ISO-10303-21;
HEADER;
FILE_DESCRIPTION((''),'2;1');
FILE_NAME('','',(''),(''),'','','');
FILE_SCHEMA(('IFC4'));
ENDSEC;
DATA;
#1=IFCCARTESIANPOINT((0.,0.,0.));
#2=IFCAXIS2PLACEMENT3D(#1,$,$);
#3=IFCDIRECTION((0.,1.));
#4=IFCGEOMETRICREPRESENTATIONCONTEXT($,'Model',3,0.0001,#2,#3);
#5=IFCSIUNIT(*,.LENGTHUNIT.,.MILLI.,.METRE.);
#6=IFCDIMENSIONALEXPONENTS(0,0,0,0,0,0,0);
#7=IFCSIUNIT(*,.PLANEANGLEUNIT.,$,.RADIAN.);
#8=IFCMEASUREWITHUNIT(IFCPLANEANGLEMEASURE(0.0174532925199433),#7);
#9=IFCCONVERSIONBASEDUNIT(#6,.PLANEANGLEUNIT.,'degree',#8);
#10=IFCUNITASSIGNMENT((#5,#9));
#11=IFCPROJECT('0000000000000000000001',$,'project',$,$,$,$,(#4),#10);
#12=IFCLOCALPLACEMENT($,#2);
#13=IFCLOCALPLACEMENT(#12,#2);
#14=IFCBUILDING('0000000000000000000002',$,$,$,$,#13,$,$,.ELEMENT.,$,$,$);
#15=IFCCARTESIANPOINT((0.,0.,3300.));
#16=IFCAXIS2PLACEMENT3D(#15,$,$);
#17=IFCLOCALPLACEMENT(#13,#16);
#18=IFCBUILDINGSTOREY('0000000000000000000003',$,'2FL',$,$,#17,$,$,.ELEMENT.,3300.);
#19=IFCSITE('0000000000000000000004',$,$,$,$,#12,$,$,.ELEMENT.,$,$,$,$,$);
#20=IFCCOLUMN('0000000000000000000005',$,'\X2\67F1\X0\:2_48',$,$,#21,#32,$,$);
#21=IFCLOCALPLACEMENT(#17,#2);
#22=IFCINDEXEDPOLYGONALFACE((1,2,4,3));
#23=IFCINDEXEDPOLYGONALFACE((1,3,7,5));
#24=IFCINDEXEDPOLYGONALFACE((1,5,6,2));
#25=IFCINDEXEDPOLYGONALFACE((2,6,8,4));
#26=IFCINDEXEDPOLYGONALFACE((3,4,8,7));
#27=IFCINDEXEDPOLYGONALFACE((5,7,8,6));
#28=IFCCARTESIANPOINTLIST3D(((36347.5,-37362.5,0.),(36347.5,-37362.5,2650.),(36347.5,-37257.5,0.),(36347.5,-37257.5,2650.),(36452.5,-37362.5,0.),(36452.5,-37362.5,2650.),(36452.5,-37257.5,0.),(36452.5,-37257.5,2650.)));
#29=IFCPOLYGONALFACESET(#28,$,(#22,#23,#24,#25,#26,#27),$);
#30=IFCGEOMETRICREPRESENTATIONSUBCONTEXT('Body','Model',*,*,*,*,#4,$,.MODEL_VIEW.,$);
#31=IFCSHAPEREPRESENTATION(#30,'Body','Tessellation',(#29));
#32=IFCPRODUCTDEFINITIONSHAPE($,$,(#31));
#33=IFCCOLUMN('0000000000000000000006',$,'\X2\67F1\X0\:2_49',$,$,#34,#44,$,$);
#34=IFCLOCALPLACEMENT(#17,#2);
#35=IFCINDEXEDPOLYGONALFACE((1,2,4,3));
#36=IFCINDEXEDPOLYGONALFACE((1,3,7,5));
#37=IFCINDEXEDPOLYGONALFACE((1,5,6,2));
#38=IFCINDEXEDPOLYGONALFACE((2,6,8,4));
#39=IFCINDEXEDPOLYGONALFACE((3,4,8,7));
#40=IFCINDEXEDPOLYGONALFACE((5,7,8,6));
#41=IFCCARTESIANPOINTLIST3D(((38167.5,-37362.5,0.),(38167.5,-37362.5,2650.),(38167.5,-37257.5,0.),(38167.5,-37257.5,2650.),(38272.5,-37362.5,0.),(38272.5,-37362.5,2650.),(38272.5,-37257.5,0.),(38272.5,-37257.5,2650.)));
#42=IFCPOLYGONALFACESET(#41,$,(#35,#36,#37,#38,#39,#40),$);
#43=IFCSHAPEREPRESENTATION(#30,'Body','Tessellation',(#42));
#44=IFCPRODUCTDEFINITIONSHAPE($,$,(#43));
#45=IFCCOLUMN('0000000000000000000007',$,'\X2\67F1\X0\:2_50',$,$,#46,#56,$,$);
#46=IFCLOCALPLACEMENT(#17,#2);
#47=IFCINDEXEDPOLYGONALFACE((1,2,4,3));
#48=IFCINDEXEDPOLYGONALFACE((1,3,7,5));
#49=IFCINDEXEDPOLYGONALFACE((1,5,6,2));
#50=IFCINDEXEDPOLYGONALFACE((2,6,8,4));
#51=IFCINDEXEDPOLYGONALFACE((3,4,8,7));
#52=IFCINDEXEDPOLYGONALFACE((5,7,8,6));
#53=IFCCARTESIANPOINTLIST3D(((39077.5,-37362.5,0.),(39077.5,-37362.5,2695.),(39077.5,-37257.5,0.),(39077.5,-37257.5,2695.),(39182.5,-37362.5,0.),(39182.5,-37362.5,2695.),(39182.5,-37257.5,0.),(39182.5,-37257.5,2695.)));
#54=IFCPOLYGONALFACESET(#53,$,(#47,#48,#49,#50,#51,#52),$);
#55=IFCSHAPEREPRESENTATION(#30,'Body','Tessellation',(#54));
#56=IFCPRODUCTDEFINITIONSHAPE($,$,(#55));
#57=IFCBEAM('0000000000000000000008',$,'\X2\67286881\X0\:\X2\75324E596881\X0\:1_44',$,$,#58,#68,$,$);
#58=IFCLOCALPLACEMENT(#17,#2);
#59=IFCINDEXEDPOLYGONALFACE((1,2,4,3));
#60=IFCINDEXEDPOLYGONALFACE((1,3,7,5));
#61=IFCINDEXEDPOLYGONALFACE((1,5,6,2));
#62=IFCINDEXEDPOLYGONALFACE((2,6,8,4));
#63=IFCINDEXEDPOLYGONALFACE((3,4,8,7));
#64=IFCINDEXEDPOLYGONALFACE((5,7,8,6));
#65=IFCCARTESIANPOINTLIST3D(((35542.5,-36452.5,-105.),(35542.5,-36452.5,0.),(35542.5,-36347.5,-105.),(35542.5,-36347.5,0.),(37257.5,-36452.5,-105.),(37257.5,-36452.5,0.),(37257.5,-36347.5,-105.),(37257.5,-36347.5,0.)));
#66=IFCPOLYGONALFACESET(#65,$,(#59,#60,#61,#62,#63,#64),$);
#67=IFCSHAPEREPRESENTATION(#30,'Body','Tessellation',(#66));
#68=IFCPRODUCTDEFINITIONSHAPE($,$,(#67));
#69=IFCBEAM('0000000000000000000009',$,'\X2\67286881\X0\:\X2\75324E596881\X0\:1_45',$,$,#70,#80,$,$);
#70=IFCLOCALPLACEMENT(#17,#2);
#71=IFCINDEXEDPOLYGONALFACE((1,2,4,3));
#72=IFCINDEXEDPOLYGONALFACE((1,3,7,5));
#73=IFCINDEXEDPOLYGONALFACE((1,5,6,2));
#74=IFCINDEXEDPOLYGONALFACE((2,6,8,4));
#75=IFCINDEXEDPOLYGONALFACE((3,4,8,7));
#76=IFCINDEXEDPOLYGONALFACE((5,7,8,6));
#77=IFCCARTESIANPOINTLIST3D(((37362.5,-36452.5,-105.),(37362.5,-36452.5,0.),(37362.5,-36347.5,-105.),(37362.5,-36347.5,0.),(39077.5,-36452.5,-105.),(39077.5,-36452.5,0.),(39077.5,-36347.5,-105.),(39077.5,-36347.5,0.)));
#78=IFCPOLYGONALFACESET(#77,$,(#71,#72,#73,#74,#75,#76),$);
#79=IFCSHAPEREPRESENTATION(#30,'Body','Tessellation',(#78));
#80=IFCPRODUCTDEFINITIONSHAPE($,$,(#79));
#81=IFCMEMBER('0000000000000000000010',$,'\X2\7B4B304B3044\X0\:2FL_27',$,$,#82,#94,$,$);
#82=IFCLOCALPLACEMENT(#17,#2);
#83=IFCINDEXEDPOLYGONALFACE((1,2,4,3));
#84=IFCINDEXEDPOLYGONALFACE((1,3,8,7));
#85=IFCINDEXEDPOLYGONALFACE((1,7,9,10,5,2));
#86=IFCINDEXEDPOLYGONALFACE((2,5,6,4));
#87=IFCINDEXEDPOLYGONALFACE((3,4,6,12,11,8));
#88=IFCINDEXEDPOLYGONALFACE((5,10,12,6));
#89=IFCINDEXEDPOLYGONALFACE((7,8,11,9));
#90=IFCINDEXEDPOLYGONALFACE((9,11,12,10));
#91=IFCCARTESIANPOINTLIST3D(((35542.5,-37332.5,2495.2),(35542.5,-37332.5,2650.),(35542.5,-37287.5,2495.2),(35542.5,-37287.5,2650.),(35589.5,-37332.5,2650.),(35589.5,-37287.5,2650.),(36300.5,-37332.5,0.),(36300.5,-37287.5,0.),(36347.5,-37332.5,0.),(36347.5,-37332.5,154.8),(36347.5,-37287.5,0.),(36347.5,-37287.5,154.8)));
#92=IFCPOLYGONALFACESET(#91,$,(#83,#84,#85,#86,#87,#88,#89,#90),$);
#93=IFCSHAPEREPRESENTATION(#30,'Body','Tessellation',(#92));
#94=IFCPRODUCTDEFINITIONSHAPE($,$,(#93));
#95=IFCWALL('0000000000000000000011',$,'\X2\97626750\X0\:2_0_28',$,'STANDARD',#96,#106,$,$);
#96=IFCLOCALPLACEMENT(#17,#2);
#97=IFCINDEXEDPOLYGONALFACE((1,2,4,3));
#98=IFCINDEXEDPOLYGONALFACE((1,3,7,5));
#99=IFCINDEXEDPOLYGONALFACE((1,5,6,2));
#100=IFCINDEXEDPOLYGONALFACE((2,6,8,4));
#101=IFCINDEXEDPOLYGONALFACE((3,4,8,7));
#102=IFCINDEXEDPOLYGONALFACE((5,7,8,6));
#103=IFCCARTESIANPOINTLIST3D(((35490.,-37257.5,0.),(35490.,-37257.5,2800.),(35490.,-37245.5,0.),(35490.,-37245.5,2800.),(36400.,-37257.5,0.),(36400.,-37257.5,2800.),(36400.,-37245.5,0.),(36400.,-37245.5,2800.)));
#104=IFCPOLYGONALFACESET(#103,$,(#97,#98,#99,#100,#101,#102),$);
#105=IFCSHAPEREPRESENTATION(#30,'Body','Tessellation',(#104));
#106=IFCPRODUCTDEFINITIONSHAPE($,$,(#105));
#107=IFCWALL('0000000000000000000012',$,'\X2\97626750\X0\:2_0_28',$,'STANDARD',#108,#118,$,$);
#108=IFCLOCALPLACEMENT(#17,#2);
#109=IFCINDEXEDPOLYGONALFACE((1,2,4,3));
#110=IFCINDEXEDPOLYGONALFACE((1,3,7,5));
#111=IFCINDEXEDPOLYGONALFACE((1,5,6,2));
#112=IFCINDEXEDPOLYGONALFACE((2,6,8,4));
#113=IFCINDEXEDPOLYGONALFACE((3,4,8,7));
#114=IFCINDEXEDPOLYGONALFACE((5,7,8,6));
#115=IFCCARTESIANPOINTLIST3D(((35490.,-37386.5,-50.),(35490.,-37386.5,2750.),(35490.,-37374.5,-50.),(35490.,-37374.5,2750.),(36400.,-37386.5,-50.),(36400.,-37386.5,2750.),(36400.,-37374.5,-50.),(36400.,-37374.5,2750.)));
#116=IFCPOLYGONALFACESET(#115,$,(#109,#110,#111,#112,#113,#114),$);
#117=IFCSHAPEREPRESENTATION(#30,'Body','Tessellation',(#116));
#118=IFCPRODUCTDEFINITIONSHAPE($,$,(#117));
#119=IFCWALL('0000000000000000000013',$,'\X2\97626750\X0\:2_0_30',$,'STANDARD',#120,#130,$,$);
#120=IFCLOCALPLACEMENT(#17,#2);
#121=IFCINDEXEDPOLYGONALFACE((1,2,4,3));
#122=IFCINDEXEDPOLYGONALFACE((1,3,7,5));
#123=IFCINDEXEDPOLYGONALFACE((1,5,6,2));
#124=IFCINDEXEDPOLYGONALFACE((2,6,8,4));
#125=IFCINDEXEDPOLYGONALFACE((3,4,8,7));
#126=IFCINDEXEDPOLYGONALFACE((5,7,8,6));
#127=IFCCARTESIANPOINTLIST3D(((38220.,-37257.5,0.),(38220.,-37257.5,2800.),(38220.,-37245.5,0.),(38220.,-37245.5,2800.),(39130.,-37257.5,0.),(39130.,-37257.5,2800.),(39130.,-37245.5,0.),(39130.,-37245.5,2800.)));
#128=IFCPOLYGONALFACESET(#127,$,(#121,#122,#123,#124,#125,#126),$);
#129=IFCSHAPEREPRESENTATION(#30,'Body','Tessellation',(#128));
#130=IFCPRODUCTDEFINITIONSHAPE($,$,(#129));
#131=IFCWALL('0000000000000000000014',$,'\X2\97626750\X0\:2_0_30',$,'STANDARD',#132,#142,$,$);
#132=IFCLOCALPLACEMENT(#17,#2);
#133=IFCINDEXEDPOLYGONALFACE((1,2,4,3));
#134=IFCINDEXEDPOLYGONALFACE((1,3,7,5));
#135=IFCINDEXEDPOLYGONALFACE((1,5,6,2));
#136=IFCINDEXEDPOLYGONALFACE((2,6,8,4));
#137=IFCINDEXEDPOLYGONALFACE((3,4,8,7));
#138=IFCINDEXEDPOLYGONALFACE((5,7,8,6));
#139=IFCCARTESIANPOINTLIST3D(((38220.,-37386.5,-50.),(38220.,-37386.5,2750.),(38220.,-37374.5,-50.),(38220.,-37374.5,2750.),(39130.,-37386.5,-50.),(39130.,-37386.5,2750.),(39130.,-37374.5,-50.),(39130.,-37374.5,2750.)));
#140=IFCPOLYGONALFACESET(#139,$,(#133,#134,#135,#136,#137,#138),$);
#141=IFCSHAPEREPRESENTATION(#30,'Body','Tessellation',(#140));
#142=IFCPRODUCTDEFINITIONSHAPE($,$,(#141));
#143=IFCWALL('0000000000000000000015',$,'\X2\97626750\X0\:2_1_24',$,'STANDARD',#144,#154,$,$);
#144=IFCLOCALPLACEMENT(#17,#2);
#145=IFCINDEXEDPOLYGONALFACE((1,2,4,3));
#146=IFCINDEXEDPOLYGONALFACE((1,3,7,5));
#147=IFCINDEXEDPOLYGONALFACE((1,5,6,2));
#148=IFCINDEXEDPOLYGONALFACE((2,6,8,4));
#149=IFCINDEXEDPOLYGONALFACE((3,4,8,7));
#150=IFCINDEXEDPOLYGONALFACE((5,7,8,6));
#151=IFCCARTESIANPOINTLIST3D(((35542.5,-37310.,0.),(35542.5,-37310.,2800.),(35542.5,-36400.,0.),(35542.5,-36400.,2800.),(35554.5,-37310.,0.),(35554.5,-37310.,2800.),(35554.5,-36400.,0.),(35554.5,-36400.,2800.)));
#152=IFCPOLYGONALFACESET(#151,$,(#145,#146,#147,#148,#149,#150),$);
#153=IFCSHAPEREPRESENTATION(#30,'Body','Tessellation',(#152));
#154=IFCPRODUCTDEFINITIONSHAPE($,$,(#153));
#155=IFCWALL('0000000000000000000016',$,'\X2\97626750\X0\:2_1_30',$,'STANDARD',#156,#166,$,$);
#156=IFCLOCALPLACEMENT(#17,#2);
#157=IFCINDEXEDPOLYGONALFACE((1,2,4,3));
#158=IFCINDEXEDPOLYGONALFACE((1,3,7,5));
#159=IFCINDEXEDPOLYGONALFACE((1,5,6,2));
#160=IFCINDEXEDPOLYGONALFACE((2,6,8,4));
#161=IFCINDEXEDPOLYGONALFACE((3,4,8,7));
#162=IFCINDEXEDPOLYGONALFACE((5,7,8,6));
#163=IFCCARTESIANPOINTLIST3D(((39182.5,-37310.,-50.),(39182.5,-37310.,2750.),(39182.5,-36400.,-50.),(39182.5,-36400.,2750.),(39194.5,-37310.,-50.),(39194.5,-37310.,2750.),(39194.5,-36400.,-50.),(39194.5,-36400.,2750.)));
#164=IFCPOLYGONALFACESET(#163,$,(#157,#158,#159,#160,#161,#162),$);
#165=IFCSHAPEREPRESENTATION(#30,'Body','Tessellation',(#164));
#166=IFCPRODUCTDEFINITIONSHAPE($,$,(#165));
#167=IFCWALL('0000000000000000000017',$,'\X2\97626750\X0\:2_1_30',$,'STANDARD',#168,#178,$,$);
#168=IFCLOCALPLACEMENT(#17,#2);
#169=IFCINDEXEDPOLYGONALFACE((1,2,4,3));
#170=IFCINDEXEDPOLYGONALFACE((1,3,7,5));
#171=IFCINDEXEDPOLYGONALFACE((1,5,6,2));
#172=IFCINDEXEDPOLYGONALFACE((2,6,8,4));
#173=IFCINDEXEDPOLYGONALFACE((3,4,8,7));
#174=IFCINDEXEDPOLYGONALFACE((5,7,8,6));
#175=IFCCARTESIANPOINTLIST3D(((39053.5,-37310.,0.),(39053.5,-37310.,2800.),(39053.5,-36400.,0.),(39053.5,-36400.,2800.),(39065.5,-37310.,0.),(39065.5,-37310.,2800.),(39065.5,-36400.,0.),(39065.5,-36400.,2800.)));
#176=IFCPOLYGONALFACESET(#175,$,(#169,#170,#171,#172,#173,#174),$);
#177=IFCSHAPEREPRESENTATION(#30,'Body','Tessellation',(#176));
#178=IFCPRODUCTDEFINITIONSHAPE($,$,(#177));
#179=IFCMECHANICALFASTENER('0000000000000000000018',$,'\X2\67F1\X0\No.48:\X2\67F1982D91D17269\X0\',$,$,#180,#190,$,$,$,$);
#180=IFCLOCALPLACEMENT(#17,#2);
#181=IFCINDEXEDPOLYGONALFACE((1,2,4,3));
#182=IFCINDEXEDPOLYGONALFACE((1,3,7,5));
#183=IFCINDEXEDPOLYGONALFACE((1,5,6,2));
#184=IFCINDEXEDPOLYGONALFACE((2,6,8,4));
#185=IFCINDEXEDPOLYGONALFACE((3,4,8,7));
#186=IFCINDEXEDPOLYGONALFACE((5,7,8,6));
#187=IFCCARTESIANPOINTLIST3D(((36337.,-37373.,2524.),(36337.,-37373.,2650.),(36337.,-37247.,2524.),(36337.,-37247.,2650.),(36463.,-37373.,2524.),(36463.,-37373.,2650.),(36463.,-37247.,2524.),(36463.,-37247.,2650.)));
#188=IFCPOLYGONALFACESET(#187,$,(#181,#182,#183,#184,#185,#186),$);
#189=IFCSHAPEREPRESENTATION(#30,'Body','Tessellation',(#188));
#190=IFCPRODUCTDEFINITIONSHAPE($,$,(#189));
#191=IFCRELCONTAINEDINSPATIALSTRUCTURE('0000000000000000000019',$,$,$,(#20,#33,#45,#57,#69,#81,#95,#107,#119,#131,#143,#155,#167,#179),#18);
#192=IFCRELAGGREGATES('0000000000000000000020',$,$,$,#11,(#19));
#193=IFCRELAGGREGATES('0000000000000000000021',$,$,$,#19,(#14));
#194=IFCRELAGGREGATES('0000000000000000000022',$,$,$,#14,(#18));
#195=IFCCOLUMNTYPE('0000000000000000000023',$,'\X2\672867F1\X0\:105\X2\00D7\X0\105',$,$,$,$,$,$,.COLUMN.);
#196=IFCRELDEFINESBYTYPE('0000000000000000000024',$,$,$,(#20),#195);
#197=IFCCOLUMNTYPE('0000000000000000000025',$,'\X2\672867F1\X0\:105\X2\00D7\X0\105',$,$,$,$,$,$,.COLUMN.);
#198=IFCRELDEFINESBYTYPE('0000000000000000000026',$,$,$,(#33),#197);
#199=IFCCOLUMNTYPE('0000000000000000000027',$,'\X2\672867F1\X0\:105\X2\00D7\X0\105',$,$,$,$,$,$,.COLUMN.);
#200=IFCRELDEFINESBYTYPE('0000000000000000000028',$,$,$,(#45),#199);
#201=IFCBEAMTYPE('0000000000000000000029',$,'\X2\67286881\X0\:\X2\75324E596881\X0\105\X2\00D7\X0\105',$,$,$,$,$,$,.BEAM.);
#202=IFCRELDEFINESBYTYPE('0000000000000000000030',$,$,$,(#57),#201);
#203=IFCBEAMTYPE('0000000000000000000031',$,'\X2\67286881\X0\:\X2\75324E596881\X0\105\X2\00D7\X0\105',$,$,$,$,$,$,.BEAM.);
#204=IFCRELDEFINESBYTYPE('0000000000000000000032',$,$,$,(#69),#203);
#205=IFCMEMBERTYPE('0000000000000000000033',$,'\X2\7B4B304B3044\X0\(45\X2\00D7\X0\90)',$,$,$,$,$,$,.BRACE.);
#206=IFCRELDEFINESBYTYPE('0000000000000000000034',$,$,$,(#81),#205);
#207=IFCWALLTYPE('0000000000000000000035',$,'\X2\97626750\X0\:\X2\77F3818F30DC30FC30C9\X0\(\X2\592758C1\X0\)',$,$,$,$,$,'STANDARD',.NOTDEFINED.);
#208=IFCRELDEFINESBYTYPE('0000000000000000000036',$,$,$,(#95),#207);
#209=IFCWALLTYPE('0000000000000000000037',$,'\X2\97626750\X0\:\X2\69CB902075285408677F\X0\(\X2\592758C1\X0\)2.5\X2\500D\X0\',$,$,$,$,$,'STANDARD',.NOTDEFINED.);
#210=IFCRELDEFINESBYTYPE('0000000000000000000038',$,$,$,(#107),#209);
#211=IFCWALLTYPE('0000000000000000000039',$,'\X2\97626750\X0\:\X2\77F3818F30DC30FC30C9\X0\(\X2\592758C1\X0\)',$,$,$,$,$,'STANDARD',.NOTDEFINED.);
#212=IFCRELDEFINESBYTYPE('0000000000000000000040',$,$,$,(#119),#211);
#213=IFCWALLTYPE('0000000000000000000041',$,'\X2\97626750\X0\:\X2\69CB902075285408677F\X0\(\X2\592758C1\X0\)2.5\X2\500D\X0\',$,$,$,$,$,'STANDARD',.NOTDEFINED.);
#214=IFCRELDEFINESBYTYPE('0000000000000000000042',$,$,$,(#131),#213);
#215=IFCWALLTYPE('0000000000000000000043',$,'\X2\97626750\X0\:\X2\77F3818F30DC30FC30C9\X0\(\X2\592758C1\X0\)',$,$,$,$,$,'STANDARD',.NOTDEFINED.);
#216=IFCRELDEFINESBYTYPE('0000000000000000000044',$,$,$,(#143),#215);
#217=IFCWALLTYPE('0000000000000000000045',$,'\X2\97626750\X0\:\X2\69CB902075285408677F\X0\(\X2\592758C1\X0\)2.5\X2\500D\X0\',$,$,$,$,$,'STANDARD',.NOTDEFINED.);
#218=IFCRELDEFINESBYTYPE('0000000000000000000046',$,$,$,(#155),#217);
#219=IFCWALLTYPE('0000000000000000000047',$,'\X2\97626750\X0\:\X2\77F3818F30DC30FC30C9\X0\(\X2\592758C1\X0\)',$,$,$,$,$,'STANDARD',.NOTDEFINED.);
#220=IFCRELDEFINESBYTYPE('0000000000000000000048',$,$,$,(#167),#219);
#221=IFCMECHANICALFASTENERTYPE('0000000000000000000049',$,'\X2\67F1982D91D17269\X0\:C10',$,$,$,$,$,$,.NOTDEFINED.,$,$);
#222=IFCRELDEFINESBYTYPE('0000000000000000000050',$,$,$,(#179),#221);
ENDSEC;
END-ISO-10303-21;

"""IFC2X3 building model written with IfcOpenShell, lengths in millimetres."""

from ifc_helpers import new_model, entity, si_unit, converted_unit, direction, frame, origin, origin_with_axes, origin_2d, place, context, subcontext, project, spatial, polyline, rectangle, outline, extrude, type_object, element, save


model = new_model("IFC2X3")

# Units and contexts
model_context = context("Model", 3, precision=0.0001, world=origin(), true_north=direction((0.0, 1.0)))
body_context = subcontext(model_context, "Body", "Model", "MODEL_VIEW")
ifc_project = project(units=[si_unit("LENGTHUNIT", "METRE", prefix="MILLI"), converted_unit("PLANEANGLEUNIT", "degree", entity("IfcPlaneAngleMeasure", 0.0174532925199433), si_unit("PLANEANGLEUNIT", "RADIAN"), dimensions=[0, 0, 0, 0, 0, 0, 0])], contexts=[model_context])

# Site, building, storey
site_placement = place(None, origin())
site = spatial("IfcSite", under=ifc_project, at=site_placement, CompositionType="ELEMENT")
building_placement = place(site_placement, origin())
building = spatial("IfcBuilding", under=site, at=building_placement, CompositionType="ELEMENT")
storey_placement = place(building_placement, frame((0.0, 0.0, 3300.0)))
storey = spatial("IfcBuildingStorey", under=building, at=storey_placement, Name="2FL", CompositionType="ELEMENT", Elevation=3300.0)

# Columns
column_type_1 = type_object("IfcColumnType", Name="木柱:105×105", PredefinedType="COLUMN")
column_1_placement = place(storey_placement, frame((36400.0, -37310.0, 0.0)))
element("IfcColumn", 1, at=column_1_placement, inside=storey, type_object=column_type_1, Name="柱:2_48", context=body_context, shape_type="SweptSolid", body=[
    extrude(rectangle(XDim=105.0, YDim=105.0, at=origin_2d()), origin_with_axes(), (0.0, 0.0, 1.0), 2650.0),
])
column_type_2 = type_object("IfcColumnType", Name="木柱:105×105", PredefinedType="COLUMN")
column_2_placement = place(storey_placement, frame((38220.0, -37310.0, 0.0)))
element("IfcColumn", 2, at=column_2_placement, inside=storey, type_object=column_type_2, Name="柱:2_49", context=body_context, shape_type="SweptSolid", body=[
    extrude(rectangle(XDim=105.0, YDim=105.0, at=origin_2d()), origin_with_axes(), (0.0, 0.0, 1.0), 2650.0),
])
column_type_3 = type_object("IfcColumnType", Name="木柱:105×105", PredefinedType="COLUMN")
column_3_placement = place(storey_placement, frame((39130.0, -37310.0, 0.0)))
element("IfcColumn", 3, at=column_3_placement, inside=storey, type_object=column_type_3, Name="柱:2_50", context=body_context, shape_type="SweptSolid", body=[
    extrude(rectangle(XDim=105.0, YDim=105.0, at=origin_2d()), origin_with_axes(), (0.0, 0.0, 1.0), 2695.0),
])

# Beams
beam_type_1 = type_object("IfcBeamType", Name="木梁:甲乙梁105×105", PredefinedType="BEAM")
beam_1_placement = place(storey_placement, frame((35542.5, -36400.0, -52.5), z_axis=(1.0, 0.0, 0.0), x_axis=(0.0, 1.0, 0.0)))
element("IfcBeam", 4, at=beam_1_placement, inside=storey, type_object=beam_type_1, Name="木梁:甲乙梁:1_44", context=body_context, shape_type="SweptSolid", body=[
    extrude(rectangle(XDim=105.0, YDim=105.0, at=origin_2d()), origin_with_axes(), (0.0, 0.0, 1.0), 1715.0),
])
beam_type_2 = type_object("IfcBeamType", Name="木梁:甲乙梁105×105", PredefinedType="BEAM")
beam_2_placement = place(storey_placement, frame((37362.5, -36400.0, -52.5), z_axis=(1.0, 0.0, 0.0), x_axis=(0.0, 1.0, 0.0)))
element("IfcBeam", 5, at=beam_2_placement, inside=storey, type_object=beam_type_2, Name="木梁:甲乙梁:1_45", context=body_context, shape_type="SweptSolid", body=[
    extrude(rectangle(XDim=105.0, YDim=105.0, at=origin_2d()), origin_with_axes(), (0.0, 0.0, 1.0), 1715.0),
])

# Member
member_type = type_object("IfcMemberType", Name="筋かい(45×90)", PredefinedType="BRACE")
member_placement = place(storey_placement, frame((36347.5, -37310.0, 0.0), z_axis=(-0.290659, 0.0, 0.956827), x_axis=(0.956827, 0.0, 0.290659)))
element("IfcMember", 6, at=member_placement, inside=storey, type_object=member_type, Name="筋かい:2FL_27", context=body_context, shape_type="SweptSolid", body=[
    extrude(outline(polyline([(0.0, 0.0), (13.7, -45.0), (2621.4, -45.0), (2769.6, 0.0), (2755.9, 45.0), (148.1, 45.0), (0.0, 0.0)])), frame((0.0, -22.5, 0.0), z_axis=(0.0, 1.0, 0.0), x_axis=(0.0, 0.0, 1.0)), (0.0, 0.0, 1.0), 45.0),
])

# Walls
wall_type_1 = type_object("IfcWallType", Name="面材:石膏ボード(大壁)", ElementType="STANDARD", PredefinedType="NOTDEFINED")
wall_1_placement = place(storey_placement, frame((35945.0, -37245.5, 0.0), z_axis=(0.0, -1.0, 0.0), x_axis=(1.0, 0.0, 0.0)))
element("IfcWall", 7, at=wall_1_placement, inside=storey, type_object=wall_type_1, Name="面材:2_0_28", ObjectType="STANDARD", context=body_context, shape_type="SweptSolid", body=[
    extrude(outline(polyline([(455.0, 0.0, 0.0), (-455.0, 0.0, 0.0), (-455.0, 2800.0, 0.0), (455.0, 2800.0, 0.0), (455.0, 0.0, 0.0)])), origin_with_axes(), (0.0, 0.0, 1.0), 12.0),
])
wall_type_2 = type_object("IfcWallType", Name="面材:構造用合板(大壁)2.5倍", ElementType="STANDARD", PredefinedType="NOTDEFINED")
wall_2_placement = place(storey_placement, frame((35945.0, -37374.5, -50.0), z_axis=(0.0, -1.0, 0.0), x_axis=(1.0, 0.0, 0.0)))
element("IfcWall", 8, at=wall_2_placement, inside=storey, type_object=wall_type_2, Name="面材:2_0_28", ObjectType="STANDARD", context=body_context, shape_type="SweptSolid", body=[
    extrude(outline(polyline([(455.0, 0.0, 0.0), (-455.0, 0.0, 0.0), (-455.0, 2800.0, 0.0), (455.0, 2800.0, 0.0), (455.0, 0.0, 0.0)])), origin_with_axes(), (0.0, 0.0, 1.0), 12.0),
])
wall_type_3 = type_object("IfcWallType", Name="面材:石膏ボード(大壁)", ElementType="STANDARD", PredefinedType="NOTDEFINED")
wall_3_placement = place(storey_placement, frame((38675.0, -37245.5, 0.0), z_axis=(0.0, -1.0, 0.0), x_axis=(1.0, 0.0, 0.0)))
element("IfcWall", 9, at=wall_3_placement, inside=storey, type_object=wall_type_3, Name="面材:2_0_30", ObjectType="STANDARD", context=body_context, shape_type="SweptSolid", body=[
    extrude(outline(polyline([(455.0, 0.0, 0.0), (-455.0, 0.0, 0.0), (-455.0, 2800.0, 0.0), (455.0, 2800.0, 0.0), (455.0, 0.0, 0.0)])), origin_with_axes(), (0.0, 0.0, 1.0), 12.0),
])
wall_type_4 = type_object("IfcWallType", Name="面材:構造用合板(大壁)2.5倍", ElementType="STANDARD", PredefinedType="NOTDEFINED")
wall_4_placement = place(storey_placement, frame((38675.0, -37374.5, -50.0), z_axis=(0.0, -1.0, 0.0), x_axis=(1.0, 0.0, 0.0)))
element("IfcWall", 10, at=wall_4_placement, inside=storey, type_object=wall_type_4, Name="面材:2_0_30", ObjectType="STANDARD", context=body_context, shape_type="SweptSolid", body=[
    extrude(outline(polyline([(455.0, 0.0, 0.0), (-455.0, 0.0, 0.0), (-455.0, 2800.0, 0.0), (455.0, 2800.0, 0.0), (455.0, 0.0, 0.0)])), origin_with_axes(), (0.0, 0.0, 1.0), 12.0),
])
wall_type_5 = type_object("IfcWallType", Name="面材:石膏ボード(大壁)", ElementType="STANDARD", PredefinedType="NOTDEFINED")
wall_5_placement = place(storey_placement, frame((35554.5, -36855.0, 0.0), z_axis=(-1.0, 0.0, 0.0), x_axis=(0.0, -1.0, 0.0)))
element("IfcWall", 11, at=wall_5_placement, inside=storey, type_object=wall_type_5, Name="面材:2_1_24", ObjectType="STANDARD", context=body_context, shape_type="SweptSolid", body=[
    extrude(outline(polyline([(455.0, 0.0, 0.0), (-455.0, 0.0, 0.0), (-455.0, 2800.0, 0.0), (455.0, 2800.0, 0.0), (455.0, 0.0, 0.0)])), origin_with_axes(), (0.0, 0.0, 1.0), 12.0),
])
wall_type_6 = type_object("IfcWallType", Name="面材:構造用合板(大壁)2.5倍", ElementType="STANDARD", PredefinedType="NOTDEFINED")
wall_6_placement = place(storey_placement, frame((39194.5, -36855.0, -50.0), z_axis=(-1.0, 0.0, 0.0), x_axis=(0.0, -1.0, 0.0)))
element("IfcWall", 12, at=wall_6_placement, inside=storey, type_object=wall_type_6, Name="面材:2_1_30", ObjectType="STANDARD", context=body_context, shape_type="SweptSolid", body=[
    extrude(outline(polyline([(455.0, 0.0, 0.0), (-455.0, 0.0, 0.0), (-455.0, 2800.0, 0.0), (455.0, 2800.0, 0.0), (455.0, 0.0, 0.0)])), origin_with_axes(), (0.0, 0.0, 1.0), 12.0),
])
wall_type_7 = type_object("IfcWallType", Name="面材:石膏ボード(大壁)", ElementType="STANDARD", PredefinedType="NOTDEFINED")
wall_7_placement = place(storey_placement, frame((39065.5, -36855.0, 0.0), z_axis=(-1.0, 0.0, 0.0), x_axis=(0.0, -1.0, 0.0)))
element("IfcWall", 13, at=wall_7_placement, inside=storey, type_object=wall_type_7, Name="面材:2_1_30", ObjectType="STANDARD", context=body_context, shape_type="SweptSolid", body=[
    extrude(outline(polyline([(455.0, 0.0, 0.0), (-455.0, 0.0, 0.0), (-455.0, 2800.0, 0.0), (455.0, 2800.0, 0.0), (455.0, 0.0, 0.0)])), origin_with_axes(), (0.0, 0.0, 1.0), 12.0),
])

# Mechanical fastener
mechanical_fastener_type_1 = type_object("IfcMechanicalFastenerType", Name="柱頭金物:C10")
mechanical_fastener_1_placement = place(storey_placement, frame((36400.0, -37310.0, 2524.0)))
element("IfcMechanicalFastener", 14, at=mechanical_fastener_1_placement, inside=storey, type_object=mechanical_fastener_type_1, Name="柱No.48:柱頭金物", context=body_context, shape_type="SweptSolid", body=[
    extrude(rectangle(XDim=126.0, YDim=126.0, at=origin_2d()), origin_with_axes(), (0.0, 0.0, 1.0), 126.0),
])

save(model, "model.ifc")
